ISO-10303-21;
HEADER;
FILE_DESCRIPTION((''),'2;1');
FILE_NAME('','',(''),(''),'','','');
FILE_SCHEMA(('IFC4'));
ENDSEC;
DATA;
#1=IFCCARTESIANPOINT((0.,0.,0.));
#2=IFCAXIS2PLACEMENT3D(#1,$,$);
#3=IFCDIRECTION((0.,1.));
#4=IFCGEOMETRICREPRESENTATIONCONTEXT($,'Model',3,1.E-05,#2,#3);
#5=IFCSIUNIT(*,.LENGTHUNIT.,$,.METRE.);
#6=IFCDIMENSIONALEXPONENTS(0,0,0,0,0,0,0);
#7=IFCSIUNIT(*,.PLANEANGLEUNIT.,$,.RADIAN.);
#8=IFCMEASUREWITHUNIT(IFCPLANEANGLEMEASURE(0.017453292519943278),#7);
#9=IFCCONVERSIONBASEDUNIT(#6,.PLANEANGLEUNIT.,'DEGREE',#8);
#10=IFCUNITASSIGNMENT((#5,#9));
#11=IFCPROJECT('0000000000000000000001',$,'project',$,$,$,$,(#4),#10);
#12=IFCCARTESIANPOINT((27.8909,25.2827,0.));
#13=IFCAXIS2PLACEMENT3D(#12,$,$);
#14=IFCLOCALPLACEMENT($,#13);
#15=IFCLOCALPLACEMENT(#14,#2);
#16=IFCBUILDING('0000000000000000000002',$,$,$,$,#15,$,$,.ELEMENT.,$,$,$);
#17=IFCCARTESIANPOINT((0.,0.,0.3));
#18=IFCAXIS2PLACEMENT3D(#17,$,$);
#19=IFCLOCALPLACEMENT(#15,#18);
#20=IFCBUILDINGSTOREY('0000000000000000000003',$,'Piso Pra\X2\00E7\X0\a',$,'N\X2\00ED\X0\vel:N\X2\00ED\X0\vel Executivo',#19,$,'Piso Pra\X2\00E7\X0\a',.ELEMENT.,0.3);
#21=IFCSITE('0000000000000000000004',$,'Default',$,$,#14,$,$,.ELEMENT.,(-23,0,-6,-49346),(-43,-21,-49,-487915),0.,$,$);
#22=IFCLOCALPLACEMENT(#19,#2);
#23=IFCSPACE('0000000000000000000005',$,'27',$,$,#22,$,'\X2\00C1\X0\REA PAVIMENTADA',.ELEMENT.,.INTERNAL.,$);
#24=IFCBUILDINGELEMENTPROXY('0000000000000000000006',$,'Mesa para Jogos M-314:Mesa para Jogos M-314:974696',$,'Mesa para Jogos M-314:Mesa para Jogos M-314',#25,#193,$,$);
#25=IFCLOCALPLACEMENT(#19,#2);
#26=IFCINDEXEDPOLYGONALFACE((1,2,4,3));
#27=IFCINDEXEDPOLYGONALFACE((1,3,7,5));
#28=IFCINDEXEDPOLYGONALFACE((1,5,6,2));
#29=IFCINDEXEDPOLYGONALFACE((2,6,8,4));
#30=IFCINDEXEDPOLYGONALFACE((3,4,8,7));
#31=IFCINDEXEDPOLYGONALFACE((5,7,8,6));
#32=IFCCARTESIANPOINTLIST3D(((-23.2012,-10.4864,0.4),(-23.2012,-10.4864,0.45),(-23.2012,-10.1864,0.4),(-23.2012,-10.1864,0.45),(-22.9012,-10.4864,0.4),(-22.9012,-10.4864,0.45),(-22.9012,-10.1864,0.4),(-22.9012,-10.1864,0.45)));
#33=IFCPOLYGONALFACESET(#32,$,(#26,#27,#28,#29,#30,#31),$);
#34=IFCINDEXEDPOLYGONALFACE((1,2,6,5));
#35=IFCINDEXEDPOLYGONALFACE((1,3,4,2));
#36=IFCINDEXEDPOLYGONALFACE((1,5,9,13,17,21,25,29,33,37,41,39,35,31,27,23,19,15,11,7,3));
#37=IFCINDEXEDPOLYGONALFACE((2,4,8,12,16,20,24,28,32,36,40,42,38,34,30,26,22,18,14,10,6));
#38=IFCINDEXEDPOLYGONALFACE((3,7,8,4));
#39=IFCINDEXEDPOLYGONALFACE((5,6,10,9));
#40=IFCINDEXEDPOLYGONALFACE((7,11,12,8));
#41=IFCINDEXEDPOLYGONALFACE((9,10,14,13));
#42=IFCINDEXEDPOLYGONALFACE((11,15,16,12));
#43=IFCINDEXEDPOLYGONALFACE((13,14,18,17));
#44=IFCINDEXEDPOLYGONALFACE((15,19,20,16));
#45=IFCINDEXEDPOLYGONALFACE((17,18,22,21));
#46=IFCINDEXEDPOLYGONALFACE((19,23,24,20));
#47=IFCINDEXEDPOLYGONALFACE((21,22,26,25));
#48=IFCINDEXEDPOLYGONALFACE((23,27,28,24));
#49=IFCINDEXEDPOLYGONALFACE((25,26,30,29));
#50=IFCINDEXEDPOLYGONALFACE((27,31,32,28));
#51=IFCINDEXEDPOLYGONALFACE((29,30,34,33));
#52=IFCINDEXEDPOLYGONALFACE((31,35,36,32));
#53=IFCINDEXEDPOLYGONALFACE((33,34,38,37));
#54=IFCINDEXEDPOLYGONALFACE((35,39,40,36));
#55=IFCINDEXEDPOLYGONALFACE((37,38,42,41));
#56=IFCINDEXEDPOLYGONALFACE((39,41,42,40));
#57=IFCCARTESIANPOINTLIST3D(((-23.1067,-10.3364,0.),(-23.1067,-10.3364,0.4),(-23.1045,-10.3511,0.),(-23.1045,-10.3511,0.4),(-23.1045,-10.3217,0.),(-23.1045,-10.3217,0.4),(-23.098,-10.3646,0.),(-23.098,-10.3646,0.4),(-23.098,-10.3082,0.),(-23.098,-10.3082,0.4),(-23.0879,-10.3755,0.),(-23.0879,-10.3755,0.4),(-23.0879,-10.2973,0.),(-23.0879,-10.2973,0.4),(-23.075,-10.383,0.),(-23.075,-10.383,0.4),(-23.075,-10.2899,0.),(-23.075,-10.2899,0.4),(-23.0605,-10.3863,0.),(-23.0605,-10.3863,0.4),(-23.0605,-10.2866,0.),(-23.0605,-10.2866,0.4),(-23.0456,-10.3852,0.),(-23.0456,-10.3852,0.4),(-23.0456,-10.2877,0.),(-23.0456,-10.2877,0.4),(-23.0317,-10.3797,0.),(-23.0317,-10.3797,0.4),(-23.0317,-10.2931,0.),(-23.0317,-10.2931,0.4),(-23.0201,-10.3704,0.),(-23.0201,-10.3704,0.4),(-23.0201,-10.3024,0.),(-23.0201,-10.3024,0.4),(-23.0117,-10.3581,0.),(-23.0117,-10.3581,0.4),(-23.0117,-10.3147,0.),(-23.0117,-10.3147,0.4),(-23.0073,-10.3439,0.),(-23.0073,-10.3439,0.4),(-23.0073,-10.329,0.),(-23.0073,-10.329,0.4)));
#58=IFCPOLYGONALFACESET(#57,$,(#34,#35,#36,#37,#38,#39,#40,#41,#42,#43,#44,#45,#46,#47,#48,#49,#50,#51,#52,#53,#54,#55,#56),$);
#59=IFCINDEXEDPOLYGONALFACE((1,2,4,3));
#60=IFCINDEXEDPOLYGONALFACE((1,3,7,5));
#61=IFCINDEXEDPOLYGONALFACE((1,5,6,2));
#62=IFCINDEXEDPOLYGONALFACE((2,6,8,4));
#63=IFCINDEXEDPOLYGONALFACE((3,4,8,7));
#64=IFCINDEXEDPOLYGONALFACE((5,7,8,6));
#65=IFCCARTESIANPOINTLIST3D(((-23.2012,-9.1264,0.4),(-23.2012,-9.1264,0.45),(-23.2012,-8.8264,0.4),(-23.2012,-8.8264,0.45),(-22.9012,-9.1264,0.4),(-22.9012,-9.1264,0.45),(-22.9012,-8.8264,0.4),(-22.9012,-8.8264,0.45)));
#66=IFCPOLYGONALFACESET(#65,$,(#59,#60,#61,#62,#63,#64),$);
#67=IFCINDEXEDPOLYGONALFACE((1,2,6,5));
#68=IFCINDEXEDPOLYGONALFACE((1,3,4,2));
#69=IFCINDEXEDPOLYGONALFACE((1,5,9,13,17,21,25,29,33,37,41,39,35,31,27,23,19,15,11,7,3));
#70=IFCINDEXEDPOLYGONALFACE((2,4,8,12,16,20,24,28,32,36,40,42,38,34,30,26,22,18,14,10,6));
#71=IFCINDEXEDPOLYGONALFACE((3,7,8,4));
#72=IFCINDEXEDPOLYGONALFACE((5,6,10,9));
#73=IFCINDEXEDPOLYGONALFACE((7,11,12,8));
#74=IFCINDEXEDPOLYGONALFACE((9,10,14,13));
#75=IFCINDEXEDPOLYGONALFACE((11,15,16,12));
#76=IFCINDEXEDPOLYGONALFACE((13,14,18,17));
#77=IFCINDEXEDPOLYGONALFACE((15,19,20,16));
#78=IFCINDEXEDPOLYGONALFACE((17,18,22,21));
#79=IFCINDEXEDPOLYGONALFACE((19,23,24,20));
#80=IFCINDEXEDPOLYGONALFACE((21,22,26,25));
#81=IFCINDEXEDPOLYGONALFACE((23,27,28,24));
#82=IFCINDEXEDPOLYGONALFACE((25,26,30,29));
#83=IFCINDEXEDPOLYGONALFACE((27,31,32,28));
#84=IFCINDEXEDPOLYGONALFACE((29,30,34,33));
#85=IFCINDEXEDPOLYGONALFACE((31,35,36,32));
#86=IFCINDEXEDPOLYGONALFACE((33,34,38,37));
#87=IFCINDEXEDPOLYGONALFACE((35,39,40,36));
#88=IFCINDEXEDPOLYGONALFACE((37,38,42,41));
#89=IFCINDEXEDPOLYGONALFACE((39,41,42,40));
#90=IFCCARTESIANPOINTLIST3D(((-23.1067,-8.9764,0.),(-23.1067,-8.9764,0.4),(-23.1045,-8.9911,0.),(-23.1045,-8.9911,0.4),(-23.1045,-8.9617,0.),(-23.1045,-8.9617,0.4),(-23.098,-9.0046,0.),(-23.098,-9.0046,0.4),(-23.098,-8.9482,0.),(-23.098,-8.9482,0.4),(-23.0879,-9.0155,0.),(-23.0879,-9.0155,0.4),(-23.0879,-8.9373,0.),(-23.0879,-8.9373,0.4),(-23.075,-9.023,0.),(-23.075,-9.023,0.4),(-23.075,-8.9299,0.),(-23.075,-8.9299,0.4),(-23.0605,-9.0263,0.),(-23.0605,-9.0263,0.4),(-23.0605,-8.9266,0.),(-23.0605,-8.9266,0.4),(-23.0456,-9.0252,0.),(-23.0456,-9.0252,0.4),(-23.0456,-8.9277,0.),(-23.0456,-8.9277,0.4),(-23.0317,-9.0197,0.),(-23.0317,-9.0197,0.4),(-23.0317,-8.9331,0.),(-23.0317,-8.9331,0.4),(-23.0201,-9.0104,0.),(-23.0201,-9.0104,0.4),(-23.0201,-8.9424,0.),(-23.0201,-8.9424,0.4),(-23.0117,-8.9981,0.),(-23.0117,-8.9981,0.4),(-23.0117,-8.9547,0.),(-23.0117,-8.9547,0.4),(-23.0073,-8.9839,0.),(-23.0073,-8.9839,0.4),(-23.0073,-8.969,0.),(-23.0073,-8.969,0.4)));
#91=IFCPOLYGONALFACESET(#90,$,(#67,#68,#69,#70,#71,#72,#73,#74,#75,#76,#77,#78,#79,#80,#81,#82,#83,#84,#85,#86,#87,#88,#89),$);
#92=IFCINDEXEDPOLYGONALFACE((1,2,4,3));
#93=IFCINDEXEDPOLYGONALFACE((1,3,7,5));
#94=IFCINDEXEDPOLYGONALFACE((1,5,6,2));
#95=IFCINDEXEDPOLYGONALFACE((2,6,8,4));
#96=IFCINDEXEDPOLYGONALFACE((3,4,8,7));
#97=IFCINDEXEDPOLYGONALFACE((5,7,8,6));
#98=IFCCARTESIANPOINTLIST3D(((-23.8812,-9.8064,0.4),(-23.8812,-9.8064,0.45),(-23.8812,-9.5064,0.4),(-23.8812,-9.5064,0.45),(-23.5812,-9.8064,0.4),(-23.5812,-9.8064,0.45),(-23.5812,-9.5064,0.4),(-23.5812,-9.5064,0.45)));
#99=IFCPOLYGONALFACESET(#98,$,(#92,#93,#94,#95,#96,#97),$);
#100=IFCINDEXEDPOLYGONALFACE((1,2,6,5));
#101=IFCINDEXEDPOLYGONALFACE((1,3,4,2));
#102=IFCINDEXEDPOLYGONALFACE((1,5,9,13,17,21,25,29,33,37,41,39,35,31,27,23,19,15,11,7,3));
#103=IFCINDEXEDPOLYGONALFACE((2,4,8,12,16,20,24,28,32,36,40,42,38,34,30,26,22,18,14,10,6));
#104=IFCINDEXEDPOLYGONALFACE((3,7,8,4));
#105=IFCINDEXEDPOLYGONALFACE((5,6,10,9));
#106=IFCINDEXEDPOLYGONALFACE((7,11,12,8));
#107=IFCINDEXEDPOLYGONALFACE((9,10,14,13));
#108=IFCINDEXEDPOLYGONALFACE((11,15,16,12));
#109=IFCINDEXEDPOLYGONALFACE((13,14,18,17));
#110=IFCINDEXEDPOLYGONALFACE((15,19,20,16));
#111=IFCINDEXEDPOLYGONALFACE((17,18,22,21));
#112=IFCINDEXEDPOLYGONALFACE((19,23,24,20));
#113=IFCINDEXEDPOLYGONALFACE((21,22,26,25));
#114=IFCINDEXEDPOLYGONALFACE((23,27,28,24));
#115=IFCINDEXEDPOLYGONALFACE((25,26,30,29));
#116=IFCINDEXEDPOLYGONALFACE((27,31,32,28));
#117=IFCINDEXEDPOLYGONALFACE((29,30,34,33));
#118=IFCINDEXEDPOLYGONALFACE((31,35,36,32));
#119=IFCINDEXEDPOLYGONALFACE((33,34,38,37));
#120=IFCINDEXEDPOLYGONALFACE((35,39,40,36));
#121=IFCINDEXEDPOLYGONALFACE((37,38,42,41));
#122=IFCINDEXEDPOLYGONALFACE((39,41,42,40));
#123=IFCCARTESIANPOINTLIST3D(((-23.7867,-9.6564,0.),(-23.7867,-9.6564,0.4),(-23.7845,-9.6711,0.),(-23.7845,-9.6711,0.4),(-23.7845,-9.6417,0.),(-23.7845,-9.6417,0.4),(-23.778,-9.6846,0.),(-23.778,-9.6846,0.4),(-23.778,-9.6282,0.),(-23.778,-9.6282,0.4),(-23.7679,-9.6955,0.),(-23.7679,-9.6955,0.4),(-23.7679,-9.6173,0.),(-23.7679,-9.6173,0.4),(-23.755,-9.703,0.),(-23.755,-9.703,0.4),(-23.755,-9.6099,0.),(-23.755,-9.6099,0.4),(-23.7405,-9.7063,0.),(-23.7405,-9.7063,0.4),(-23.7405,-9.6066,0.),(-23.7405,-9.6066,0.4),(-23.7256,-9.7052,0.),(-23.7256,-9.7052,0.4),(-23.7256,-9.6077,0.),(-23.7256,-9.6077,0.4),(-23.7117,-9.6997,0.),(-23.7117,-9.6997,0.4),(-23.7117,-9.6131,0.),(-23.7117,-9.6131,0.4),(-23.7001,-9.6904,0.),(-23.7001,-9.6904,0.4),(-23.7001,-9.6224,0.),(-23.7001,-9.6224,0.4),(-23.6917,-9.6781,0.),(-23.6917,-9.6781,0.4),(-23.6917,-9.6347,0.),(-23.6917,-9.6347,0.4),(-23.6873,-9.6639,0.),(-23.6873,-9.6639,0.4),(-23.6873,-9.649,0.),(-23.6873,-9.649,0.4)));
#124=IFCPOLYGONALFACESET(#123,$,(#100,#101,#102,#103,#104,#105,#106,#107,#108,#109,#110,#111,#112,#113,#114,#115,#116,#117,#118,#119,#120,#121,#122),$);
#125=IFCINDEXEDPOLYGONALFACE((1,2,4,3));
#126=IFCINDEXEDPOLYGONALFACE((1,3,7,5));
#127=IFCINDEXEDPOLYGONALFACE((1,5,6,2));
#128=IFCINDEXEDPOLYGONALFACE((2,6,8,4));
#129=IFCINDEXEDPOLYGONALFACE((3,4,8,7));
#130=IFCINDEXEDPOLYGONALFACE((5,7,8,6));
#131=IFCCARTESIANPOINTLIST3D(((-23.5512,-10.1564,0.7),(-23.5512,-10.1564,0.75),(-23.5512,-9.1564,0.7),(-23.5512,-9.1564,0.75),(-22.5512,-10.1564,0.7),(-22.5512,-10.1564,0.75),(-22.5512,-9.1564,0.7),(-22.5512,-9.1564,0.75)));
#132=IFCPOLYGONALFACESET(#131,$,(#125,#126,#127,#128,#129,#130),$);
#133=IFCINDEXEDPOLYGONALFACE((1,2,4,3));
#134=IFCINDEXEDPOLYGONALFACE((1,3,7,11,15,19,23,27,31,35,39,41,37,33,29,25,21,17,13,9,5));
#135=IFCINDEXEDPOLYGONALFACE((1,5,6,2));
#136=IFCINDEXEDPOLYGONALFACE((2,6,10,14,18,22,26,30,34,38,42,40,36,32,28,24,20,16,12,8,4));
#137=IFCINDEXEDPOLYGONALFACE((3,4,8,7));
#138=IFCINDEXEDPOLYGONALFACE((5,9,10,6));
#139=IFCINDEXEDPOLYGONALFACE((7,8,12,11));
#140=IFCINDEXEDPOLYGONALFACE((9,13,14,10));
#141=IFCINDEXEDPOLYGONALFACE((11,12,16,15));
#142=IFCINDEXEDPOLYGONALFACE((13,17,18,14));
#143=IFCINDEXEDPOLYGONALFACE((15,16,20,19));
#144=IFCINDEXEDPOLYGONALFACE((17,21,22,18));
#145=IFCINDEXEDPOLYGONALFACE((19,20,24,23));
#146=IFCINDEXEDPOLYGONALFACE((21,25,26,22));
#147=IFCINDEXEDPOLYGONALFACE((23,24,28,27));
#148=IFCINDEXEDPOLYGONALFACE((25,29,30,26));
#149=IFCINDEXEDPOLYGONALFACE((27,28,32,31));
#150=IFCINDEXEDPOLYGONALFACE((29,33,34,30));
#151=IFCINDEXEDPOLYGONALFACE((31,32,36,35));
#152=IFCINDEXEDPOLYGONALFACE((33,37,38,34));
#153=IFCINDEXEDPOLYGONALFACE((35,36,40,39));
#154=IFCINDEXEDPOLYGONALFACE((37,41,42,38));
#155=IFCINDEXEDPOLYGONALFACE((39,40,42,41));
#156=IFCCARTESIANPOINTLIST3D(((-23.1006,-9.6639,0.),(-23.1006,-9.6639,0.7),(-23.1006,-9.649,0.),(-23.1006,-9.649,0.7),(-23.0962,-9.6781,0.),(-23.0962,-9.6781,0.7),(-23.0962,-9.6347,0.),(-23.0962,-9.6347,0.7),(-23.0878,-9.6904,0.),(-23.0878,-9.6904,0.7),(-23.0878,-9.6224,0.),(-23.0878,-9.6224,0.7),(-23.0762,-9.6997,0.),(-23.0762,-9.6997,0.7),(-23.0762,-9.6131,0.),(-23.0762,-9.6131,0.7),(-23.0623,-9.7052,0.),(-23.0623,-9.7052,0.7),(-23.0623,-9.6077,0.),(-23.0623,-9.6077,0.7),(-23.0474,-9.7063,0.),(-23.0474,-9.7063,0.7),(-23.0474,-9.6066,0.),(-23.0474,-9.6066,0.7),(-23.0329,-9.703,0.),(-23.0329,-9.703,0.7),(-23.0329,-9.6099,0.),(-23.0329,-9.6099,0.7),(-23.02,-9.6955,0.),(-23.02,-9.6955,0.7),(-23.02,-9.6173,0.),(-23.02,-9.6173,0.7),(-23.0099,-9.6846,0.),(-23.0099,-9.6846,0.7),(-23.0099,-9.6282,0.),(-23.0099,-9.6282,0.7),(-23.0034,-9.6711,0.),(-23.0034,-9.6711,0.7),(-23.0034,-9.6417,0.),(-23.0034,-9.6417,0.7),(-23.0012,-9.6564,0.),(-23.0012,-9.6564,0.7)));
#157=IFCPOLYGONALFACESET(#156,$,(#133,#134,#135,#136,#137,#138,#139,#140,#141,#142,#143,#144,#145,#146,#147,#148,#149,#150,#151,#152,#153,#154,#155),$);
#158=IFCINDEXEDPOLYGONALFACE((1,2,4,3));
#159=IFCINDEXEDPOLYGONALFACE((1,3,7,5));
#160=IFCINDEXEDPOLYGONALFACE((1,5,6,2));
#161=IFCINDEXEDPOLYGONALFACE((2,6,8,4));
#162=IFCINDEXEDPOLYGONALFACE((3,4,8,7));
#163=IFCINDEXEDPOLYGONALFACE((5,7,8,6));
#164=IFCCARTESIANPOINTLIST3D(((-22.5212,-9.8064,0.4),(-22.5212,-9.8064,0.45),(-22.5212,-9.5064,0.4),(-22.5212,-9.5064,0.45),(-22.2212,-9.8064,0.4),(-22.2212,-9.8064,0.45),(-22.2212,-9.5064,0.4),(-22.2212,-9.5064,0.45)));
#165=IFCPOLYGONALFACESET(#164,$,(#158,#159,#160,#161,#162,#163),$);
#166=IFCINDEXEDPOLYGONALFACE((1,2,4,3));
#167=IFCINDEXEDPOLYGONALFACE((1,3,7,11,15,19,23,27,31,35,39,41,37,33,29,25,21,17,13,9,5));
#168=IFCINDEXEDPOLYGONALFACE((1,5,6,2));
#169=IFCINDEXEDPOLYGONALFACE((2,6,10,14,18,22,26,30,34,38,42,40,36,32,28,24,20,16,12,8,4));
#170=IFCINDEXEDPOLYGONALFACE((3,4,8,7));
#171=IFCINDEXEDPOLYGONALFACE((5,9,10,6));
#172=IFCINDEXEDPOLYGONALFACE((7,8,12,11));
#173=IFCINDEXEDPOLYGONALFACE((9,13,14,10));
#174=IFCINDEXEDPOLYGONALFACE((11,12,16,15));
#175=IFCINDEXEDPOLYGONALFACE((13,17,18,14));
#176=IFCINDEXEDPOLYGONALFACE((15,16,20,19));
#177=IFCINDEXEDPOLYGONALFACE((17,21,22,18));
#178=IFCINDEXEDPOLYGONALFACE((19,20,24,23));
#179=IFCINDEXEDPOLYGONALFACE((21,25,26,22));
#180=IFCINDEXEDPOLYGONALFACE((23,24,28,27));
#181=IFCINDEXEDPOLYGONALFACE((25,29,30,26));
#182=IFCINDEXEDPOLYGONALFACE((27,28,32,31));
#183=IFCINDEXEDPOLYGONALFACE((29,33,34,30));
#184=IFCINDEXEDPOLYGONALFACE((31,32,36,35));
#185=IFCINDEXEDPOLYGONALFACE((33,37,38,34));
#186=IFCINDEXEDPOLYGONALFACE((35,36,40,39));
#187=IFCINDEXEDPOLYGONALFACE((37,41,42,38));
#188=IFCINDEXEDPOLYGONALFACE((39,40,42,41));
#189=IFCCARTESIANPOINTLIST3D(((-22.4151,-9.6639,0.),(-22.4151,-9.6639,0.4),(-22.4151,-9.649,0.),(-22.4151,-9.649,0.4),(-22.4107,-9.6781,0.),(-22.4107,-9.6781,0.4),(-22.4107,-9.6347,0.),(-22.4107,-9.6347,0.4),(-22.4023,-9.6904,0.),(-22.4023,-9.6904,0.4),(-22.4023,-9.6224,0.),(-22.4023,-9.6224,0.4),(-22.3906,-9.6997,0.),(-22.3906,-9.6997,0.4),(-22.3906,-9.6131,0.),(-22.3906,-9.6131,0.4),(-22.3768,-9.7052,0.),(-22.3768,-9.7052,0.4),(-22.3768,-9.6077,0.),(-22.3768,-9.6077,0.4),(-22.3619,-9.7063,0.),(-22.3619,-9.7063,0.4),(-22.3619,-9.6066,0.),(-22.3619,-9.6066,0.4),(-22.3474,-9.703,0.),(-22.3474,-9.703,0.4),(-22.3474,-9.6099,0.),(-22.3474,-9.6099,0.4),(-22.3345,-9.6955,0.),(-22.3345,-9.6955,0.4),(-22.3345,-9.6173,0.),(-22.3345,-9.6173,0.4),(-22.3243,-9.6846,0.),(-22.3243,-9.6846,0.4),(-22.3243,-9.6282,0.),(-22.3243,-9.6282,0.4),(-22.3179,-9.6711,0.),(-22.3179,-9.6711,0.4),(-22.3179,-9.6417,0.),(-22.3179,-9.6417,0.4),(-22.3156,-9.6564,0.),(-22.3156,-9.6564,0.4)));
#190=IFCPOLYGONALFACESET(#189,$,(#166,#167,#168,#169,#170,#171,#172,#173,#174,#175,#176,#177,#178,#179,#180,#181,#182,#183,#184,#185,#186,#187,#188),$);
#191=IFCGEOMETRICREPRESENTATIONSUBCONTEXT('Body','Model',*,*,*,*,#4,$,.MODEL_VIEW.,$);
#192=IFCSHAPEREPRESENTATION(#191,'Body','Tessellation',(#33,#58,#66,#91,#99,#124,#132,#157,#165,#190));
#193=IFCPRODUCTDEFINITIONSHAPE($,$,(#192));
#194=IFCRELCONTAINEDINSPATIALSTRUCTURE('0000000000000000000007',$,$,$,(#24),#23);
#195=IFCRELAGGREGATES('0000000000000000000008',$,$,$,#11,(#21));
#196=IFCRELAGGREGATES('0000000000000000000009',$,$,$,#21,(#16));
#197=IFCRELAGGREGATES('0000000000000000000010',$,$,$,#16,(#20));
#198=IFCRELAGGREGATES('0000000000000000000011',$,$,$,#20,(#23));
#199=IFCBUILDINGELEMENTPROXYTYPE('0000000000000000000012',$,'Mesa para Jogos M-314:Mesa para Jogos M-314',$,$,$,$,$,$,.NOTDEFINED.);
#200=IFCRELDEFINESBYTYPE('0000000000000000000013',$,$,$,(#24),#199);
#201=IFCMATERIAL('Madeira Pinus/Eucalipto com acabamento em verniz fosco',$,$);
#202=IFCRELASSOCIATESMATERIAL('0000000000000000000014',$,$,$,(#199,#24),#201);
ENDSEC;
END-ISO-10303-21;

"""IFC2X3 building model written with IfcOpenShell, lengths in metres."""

from ifc_helpers import new_model, entity, si_unit, converted_unit, direction, frame, frame_2d, origin, place, context, subcontext, project, spatial, rectangle, circle, extrude, source, transform, mapped, material, type_object, type_shapes, element, save


model = new_model("IFC2X3")

# Units and contexts
model_context = context("Model", 3, precision=1e-05, world=origin(), true_north=direction((0.0, 1.0)))
body_context = subcontext(model_context, "Body", "Model", "MODEL_VIEW")
ifc_project = project(units=[si_unit("LENGTHUNIT", "METRE"), converted_unit("PLANEANGLEUNIT", "DEGREE", entity("IfcPlaneAngleMeasure", 0.017453292519943278), si_unit("PLANEANGLEUNIT", "RADIAN"), dimensions=[0, 0, 0, 0, 0, 0, 0])], contexts=[model_context])

# Site, building, storey
site_placement = place(None, frame((27.8909, 25.2827, 0.0)))
site = spatial("IfcSite", under=ifc_project, at=site_placement, Name="Default", CompositionType="ELEMENT", RefLatitude=(-23, 0, -6, -49346), RefLongitude=(-43, -21, -49, -487915), RefElevation=0.0)
building_placement = place(site_placement, origin())
building = spatial("IfcBuilding", under=site, at=building_placement, CompositionType="ELEMENT")
storey_placement = place(building_placement, frame((0.0, 0.0, 0.3)))
storey = spatial("IfcBuildingStorey", under=building, at=storey_placement, Name="Piso Praça", ObjectType="Nível:Nível Executivo", LongName="Piso Praça", CompositionType="ELEMENT", Elevation=0.3)

# Shared definitions
space_placement = place(storey_placement, origin())
space = spatial("IfcSpace", under=storey, at=space_placement, Name="27", LongName="ÁREA PAVIMENTADA", CompositionType="ELEMENT", InteriorOrExteriorSpace="INTERNAL")

# Building element proxy
ifc_material_1 = material(Name="Madeira Pinus/Eucalipto com acabamento em verniz fosco")
building_element_proxy_type_1 = type_object("IfcBuildingElementProxyType", Name="Mesa para Jogos M-314:Mesa para Jogos M-314", PredefinedType="NOTDEFINED", material=ifc_material_1)
shared_shape_1 = source(origin(), body_context, "Body", "SweptSolid", [
    extrude(rectangle(XDim=0.3, YDim=0.3, at=frame_2d((0.0, 0.0), x_axis=(1.0, 0.0))), frame((0.0, -0.68, 0.4)), (0.0, 0.0, 1.0), 0.05),
    extrude(circle(Radius=0.05, at=frame_2d((0.0, 0.0), x_axis=(1.0, 0.0))), frame((-0.0055, -0.68, 0.0), z_axis=(0.0, 0.0, 1.0), x_axis=(-1.0, 0.0, 0.0)), (0.0, 0.0, 1.0), 0.4),
    extrude(rectangle(XDim=0.3, YDim=0.3, at=frame_2d((0.0, 0.0), x_axis=(1.0, 0.0))), frame((0.0, 0.68, 0.4), z_axis=(0.0, 0.0, 1.0), x_axis=(0.0, -1.0, 0.0)), (0.0, 0.0, 1.0), 0.05),
    extrude(circle(Radius=0.05, at=frame_2d((0.0, 0.0), x_axis=(1.0, 0.0))), frame((-0.0055, 0.68, 0.0), z_axis=(0.0, 0.0, 1.0), x_axis=(-1.0, 0.0, 0.0)), (0.0, 0.0, 1.0), 0.4),
    extrude(rectangle(XDim=0.3, YDim=0.3, at=frame_2d((0.0, 0.0), x_axis=(1.0, 0.0))), frame((-0.68, 0.0, 0.4), z_axis=(0.0, 0.0, 1.0), x_axis=(0.0, -1.0, 0.0)), (0.0, 0.0, 1.0), 0.05),
    extrude(circle(Radius=0.05, at=frame_2d((0.0, 0.0), x_axis=(1.0, 0.0))), frame((-0.6855, 0.0, 0.0), z_axis=(0.0, 0.0, 1.0), x_axis=(-1.0, 0.0, 0.0)), (0.0, 0.0, 1.0), 0.4),
    extrude(rectangle(XDim=1.0, YDim=1.0, at=frame_2d((0.0, 0.0), x_axis=(1.0, 0.0))), frame((0.0, 0.0, 0.7), z_axis=(0.0, 0.0, 1.0), x_axis=(-1.0, 0.0, 0.0)), (0.0, 0.0, 1.0), 0.05),
    extrude(circle(Radius=0.05, at=frame_2d((0.0, 0.0), x_axis=(1.0, 0.0))), origin(), (0.0, 0.0, 1.0), 0.7),
    extrude(rectangle(XDim=0.3, YDim=0.3, at=frame_2d((0.0, 0.0), x_axis=(1.0, 0.0))), frame((0.68, 0.0, 0.4), z_axis=(0.0, 0.0, 1.0), x_axis=(-1.0, 0.0, 0.0)), (0.0, 0.0, 1.0), 0.05),
    extrude(circle(Radius=0.05, at=frame_2d((0.0, 0.0), x_axis=(1.0, 0.0))), frame((0.6855, 0.0, 0.0)), (0.0, 0.0, 1.0), 0.4),
])
type_shapes(building_element_proxy_type_1, [shared_shape_1])
proxy_1_placement = place(space_placement, frame((-23.0512, -9.6564, 0.0)))
element("IfcBuildingElementProxy", 1, at=proxy_1_placement, inside=space, type_object=building_element_proxy_type_1, material=ifc_material_1, Name="Mesa para Jogos M-314:Mesa para Jogos M-314:974696", ObjectType="Mesa para Jogos M-314:Mesa para Jogos M-314", context=body_context, shape_type="MappedRepresentation", body=[
    mapped(shared_shape_1, transform((0.0, 0.0, 0.0), scale=1.0)),
])

save(model, "model.ifc")
